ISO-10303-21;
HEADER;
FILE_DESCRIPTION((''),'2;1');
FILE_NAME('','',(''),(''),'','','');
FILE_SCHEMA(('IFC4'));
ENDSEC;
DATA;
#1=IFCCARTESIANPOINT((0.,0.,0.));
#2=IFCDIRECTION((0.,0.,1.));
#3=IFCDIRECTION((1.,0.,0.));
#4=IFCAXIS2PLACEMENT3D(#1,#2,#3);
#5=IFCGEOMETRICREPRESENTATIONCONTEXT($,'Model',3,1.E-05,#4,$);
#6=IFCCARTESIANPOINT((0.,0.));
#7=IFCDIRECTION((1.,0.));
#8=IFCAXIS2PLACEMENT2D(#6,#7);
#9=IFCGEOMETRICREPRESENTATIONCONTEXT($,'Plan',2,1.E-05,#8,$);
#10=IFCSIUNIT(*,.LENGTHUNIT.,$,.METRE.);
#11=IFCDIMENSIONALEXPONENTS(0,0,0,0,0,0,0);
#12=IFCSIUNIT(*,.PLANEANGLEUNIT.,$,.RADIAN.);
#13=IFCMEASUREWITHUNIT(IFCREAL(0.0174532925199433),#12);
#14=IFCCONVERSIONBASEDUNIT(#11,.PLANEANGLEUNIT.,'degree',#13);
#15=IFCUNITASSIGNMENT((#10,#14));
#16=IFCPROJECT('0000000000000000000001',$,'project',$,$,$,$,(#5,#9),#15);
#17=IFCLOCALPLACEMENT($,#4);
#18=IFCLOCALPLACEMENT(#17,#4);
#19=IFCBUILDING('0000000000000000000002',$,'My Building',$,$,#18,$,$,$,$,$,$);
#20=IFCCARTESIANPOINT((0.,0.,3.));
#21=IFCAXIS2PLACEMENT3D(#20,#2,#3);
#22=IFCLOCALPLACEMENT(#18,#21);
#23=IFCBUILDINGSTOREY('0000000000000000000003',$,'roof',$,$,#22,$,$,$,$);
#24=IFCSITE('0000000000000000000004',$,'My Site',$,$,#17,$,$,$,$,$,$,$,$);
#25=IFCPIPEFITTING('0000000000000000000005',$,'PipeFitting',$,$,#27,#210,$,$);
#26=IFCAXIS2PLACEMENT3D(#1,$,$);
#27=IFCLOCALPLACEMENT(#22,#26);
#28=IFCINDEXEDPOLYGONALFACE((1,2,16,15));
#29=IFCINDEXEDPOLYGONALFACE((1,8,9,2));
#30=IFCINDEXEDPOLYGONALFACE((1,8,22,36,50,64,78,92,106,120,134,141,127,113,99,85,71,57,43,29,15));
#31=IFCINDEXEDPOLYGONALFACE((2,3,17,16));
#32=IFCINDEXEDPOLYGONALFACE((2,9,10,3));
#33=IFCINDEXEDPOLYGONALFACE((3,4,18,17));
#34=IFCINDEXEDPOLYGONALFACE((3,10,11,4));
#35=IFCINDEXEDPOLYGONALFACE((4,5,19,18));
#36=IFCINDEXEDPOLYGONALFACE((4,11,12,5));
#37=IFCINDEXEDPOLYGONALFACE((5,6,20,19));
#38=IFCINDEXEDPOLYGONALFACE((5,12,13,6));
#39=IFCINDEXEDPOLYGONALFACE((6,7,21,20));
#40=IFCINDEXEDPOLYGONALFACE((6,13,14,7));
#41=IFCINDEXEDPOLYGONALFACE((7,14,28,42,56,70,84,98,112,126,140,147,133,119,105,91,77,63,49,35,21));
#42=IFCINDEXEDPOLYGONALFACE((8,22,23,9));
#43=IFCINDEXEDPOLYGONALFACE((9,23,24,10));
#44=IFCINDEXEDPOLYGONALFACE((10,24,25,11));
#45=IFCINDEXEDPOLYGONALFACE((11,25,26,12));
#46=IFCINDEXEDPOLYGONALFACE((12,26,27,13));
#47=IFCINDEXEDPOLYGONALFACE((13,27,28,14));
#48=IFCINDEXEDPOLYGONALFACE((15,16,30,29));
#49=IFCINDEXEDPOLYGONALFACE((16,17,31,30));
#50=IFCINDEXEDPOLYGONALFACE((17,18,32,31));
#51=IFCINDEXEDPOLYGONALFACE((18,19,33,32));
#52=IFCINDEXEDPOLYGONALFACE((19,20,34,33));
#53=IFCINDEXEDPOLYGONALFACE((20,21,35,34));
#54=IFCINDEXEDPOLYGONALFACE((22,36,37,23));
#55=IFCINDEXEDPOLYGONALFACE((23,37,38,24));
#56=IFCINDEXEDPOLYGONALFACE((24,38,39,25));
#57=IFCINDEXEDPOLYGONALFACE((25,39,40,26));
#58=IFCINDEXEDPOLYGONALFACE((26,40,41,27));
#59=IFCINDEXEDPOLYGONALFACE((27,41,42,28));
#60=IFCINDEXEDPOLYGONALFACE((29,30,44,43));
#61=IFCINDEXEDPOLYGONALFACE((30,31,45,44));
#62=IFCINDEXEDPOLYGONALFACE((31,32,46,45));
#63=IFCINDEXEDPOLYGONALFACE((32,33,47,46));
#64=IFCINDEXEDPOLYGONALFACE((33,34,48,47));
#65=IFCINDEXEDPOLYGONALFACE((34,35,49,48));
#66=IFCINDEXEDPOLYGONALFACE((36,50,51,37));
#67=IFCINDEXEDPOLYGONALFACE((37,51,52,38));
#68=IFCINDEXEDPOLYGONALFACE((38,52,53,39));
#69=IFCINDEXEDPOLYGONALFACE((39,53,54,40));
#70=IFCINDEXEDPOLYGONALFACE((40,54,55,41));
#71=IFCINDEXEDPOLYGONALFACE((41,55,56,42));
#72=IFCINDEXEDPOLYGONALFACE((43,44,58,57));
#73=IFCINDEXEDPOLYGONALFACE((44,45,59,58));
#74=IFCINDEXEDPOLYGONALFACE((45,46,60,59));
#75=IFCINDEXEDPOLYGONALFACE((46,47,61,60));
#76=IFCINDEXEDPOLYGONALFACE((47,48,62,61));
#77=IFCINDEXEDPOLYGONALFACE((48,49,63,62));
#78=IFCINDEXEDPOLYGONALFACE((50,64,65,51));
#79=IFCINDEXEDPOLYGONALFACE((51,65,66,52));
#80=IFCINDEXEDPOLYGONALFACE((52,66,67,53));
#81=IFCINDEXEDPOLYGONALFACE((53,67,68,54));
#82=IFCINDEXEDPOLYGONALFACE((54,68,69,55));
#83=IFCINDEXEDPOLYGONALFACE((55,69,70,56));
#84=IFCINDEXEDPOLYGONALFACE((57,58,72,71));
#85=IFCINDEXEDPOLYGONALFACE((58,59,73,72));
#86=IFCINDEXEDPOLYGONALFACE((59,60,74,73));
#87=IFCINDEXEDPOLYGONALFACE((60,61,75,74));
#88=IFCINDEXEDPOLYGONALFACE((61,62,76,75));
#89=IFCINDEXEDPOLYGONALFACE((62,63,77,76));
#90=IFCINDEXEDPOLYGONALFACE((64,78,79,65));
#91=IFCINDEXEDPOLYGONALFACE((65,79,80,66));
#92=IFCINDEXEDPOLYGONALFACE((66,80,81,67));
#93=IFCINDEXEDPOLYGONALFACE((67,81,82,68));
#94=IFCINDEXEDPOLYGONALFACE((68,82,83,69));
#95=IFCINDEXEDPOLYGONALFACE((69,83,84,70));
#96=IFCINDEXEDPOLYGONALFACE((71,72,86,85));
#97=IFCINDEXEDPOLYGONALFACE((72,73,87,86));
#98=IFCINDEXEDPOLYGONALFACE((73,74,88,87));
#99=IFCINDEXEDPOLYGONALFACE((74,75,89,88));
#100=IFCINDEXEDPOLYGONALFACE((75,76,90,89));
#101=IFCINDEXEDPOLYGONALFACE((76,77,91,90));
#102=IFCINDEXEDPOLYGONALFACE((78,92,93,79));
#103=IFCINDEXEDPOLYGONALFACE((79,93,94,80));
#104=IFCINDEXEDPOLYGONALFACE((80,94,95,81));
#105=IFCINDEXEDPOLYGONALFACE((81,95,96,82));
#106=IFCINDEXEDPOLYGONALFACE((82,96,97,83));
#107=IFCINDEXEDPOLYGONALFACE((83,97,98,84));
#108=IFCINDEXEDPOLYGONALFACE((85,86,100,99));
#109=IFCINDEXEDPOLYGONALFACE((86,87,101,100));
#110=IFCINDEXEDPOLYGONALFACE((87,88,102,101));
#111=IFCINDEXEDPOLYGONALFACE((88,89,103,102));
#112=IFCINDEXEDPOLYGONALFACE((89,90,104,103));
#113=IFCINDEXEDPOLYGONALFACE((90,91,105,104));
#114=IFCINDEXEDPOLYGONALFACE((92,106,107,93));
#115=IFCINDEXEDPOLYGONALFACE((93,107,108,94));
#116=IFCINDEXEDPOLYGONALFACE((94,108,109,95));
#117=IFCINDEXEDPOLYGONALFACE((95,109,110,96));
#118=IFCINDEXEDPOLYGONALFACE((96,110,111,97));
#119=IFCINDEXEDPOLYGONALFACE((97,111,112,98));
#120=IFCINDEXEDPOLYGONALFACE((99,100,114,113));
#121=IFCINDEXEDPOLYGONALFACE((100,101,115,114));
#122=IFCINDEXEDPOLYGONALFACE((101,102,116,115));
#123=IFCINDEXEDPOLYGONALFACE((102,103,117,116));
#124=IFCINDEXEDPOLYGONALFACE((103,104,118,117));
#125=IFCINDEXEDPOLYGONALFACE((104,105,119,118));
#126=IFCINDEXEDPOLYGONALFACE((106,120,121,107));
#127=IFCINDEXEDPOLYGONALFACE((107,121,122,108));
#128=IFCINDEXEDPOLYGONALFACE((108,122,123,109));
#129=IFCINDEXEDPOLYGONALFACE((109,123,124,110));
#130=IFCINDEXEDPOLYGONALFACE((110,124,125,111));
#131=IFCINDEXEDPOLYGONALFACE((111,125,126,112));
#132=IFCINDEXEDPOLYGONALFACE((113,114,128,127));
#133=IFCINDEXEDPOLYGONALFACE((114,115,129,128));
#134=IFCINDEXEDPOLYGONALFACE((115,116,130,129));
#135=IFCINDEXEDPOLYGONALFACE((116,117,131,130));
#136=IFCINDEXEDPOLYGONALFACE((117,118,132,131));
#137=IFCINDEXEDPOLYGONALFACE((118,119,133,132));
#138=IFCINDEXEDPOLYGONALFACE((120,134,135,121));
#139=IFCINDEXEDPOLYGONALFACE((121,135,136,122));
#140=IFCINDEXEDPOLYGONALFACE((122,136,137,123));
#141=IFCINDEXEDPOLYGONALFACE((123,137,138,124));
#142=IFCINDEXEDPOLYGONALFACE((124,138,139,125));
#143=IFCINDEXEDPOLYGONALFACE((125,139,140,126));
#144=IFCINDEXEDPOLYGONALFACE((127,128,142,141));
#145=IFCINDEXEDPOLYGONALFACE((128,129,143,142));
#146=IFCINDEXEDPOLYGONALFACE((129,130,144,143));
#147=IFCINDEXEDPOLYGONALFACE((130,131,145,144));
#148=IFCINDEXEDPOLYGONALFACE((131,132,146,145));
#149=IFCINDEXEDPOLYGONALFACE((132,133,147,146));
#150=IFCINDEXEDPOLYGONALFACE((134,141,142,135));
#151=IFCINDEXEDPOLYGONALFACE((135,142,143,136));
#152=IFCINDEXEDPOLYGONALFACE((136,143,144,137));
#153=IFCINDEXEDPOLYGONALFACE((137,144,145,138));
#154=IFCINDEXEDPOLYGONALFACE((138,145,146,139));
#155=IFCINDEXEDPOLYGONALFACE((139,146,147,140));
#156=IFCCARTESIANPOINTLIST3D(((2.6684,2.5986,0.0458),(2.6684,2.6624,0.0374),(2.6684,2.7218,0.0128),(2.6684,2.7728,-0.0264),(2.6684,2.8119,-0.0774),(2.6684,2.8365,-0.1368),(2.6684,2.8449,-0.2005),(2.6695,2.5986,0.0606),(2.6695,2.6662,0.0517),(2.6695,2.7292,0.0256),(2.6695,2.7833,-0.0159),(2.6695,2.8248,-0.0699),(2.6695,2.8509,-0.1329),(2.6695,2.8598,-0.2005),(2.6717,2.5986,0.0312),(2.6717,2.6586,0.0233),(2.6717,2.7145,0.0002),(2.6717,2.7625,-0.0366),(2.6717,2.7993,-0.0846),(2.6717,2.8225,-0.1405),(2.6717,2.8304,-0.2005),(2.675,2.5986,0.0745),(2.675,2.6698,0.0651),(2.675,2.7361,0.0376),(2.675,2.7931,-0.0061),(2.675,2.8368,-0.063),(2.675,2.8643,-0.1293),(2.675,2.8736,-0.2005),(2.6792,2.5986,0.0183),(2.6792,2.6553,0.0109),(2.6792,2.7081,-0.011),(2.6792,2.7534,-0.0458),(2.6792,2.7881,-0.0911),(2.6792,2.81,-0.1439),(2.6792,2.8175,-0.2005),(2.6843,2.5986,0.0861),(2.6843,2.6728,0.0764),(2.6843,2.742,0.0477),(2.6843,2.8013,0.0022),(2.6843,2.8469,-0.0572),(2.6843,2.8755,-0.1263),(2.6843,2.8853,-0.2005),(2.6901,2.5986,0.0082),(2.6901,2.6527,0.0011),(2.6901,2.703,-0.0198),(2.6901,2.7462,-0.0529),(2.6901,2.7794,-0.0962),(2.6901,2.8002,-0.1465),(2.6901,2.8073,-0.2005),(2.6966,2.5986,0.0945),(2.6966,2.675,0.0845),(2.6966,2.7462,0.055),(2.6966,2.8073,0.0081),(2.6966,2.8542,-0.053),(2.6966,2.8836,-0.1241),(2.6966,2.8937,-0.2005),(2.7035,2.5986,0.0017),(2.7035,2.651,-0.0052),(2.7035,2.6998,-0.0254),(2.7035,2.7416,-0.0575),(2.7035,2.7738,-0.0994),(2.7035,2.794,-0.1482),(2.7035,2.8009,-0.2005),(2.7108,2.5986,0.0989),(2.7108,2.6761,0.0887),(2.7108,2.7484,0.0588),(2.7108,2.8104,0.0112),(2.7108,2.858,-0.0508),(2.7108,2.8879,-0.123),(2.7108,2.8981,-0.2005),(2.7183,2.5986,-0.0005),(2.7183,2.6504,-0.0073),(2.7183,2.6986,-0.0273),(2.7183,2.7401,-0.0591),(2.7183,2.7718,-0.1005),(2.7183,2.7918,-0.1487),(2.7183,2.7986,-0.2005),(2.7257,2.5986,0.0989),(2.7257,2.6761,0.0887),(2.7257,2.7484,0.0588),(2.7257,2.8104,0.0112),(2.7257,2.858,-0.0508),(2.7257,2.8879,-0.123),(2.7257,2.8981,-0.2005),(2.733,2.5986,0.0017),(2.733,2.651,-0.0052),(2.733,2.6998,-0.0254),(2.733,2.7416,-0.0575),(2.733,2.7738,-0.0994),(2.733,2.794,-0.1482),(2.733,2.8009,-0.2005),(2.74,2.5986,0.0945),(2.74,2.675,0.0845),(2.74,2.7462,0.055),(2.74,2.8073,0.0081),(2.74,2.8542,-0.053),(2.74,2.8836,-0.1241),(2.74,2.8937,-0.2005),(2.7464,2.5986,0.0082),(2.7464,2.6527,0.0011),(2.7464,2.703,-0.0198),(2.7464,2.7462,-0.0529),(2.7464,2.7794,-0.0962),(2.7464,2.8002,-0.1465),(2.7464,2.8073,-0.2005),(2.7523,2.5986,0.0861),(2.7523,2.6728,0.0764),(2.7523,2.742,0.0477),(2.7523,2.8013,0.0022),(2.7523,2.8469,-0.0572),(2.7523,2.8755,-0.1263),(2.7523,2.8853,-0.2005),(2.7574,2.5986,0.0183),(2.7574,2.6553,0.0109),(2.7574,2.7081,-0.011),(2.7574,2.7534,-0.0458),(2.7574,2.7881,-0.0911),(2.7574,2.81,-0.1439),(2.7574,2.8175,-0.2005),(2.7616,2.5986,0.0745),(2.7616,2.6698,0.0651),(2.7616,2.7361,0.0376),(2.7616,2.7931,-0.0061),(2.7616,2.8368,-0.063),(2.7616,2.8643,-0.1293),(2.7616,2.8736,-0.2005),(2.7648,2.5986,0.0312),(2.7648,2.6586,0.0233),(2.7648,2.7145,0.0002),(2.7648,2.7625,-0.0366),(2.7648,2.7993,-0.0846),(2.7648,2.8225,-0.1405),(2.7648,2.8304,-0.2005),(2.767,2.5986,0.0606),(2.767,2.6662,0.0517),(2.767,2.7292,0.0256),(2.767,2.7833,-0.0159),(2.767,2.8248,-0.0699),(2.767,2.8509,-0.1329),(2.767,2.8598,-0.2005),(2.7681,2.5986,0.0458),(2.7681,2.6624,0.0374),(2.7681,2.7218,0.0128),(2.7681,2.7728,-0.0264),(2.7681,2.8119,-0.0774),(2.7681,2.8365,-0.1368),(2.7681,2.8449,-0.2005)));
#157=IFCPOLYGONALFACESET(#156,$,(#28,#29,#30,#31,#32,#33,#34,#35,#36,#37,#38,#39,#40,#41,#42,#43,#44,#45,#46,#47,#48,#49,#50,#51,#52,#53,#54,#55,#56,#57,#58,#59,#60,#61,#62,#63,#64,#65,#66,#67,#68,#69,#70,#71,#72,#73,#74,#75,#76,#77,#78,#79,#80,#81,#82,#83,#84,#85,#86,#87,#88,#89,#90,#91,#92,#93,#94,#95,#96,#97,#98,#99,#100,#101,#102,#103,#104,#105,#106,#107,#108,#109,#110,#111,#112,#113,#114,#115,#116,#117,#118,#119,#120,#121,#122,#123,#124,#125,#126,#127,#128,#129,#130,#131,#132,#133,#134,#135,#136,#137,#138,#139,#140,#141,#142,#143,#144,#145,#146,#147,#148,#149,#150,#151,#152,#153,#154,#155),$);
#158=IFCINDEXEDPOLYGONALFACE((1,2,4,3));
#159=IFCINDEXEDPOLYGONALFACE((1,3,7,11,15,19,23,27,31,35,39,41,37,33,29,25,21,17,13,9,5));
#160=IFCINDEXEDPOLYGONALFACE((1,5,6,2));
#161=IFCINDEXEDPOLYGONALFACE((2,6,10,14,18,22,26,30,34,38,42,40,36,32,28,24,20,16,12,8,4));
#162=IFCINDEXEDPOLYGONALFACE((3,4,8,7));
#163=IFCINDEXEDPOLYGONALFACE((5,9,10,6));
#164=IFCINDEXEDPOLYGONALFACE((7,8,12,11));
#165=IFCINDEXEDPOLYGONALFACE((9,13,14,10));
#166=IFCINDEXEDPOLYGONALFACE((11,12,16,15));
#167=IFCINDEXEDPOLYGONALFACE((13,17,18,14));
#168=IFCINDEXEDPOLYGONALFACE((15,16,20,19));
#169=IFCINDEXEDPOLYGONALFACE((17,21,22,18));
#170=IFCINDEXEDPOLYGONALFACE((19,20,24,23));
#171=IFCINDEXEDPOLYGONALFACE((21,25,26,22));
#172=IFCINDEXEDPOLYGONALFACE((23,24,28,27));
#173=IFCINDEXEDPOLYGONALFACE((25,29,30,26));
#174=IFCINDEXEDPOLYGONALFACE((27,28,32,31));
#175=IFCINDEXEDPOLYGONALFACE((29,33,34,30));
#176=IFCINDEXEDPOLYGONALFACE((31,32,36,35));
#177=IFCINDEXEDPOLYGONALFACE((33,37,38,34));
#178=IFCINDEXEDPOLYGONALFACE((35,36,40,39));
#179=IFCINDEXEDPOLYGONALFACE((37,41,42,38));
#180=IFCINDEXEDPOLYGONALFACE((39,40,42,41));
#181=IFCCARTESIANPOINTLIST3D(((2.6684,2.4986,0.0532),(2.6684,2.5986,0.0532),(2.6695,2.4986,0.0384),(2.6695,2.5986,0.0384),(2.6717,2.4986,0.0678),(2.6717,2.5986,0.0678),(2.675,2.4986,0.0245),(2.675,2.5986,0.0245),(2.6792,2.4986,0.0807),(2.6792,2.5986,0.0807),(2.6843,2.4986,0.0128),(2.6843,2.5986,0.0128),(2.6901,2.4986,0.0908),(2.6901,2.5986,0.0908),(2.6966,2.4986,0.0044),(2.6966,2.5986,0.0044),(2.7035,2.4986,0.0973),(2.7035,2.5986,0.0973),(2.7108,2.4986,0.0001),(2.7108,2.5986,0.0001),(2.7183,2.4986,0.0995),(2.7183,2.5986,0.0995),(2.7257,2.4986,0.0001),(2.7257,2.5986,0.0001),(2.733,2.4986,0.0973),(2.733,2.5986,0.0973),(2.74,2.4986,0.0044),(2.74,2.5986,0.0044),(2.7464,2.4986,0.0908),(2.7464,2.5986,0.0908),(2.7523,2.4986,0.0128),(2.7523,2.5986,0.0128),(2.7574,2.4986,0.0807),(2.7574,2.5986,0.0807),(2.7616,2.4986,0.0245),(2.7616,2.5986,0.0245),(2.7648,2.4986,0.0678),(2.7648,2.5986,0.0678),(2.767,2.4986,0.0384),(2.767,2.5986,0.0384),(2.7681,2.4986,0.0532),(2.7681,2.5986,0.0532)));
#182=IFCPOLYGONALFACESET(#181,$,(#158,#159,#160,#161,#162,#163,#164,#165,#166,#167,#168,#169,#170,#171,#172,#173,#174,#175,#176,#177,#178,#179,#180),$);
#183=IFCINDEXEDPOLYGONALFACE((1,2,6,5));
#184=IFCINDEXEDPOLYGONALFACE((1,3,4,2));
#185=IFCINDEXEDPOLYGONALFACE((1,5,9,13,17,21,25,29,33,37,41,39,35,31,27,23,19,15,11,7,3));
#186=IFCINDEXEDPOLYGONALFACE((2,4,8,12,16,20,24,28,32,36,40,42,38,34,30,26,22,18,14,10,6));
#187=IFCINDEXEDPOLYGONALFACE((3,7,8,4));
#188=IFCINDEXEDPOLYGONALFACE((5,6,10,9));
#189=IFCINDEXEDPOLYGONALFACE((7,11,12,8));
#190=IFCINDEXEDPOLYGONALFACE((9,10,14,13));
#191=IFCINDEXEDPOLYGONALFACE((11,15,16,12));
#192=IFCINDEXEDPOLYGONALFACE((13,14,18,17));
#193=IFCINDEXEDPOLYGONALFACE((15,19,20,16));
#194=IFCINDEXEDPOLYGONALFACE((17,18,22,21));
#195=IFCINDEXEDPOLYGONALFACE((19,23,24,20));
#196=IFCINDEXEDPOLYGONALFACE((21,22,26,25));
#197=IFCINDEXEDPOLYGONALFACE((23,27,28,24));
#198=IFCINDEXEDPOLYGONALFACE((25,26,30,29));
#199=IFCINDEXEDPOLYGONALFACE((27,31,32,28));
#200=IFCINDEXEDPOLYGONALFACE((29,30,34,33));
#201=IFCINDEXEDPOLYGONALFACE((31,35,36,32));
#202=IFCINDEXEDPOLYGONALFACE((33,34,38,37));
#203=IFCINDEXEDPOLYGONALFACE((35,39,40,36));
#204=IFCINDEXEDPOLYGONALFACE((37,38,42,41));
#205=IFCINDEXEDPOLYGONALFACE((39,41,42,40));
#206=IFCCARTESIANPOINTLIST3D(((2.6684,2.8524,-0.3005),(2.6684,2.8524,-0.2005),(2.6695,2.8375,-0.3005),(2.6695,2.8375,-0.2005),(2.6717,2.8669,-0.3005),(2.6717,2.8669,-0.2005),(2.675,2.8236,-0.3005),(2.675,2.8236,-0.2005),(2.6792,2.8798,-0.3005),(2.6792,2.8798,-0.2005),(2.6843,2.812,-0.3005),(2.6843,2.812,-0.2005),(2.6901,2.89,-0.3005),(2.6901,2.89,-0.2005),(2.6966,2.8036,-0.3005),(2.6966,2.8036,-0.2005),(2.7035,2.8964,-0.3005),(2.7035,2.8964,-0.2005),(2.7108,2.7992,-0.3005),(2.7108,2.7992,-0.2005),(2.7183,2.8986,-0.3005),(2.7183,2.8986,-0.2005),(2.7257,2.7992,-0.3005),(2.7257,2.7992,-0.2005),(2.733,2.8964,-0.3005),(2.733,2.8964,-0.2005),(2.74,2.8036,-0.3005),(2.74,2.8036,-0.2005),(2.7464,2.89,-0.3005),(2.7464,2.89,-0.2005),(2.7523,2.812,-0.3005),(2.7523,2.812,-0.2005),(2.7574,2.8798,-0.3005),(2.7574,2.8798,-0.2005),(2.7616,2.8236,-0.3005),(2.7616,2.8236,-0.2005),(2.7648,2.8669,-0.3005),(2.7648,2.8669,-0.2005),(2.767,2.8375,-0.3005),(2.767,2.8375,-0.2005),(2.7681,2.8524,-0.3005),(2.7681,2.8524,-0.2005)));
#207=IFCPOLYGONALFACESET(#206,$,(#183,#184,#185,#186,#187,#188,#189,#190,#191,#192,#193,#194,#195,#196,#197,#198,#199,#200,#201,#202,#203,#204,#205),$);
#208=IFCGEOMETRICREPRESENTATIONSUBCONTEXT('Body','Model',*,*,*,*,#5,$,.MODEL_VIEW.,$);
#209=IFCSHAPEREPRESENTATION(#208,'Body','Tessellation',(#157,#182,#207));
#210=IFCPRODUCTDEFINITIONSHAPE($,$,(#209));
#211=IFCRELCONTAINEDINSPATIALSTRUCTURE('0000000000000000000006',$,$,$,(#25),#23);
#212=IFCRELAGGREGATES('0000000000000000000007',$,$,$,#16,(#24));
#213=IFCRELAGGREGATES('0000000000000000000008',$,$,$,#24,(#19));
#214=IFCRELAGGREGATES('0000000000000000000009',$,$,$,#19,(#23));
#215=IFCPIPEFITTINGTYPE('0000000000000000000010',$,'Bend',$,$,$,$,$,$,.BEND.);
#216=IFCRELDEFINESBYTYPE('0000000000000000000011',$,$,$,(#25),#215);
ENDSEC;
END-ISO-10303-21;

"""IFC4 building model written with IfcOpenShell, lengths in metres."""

from ifc_helpers import new_model, entity, si_unit, converted_unit, frame, origin_with_axes, origin_2d_with_axis, place, context, subcontext, project, spatial, circle, extrude, source, transform, mapped, type_object, type_shapes, element, save


model = new_model("IFC4")

# Units and contexts
model_context = context("Model", 3, precision=1e-05, world=origin_with_axes())
plan_context = context("Plan", 2, precision=1e-05, world=origin_2d_with_axis())
body_context = subcontext(model_context, "Body", "Model", "MODEL_VIEW")
ifc_project = project(units=[si_unit("LENGTHUNIT", "METRE"), converted_unit("PLANEANGLEUNIT", "degree", entity("IfcReal", 0.0174532925199433), si_unit("PLANEANGLEUNIT", "RADIAN"), dimensions=[0, 0, 0, 0, 0, 0, 0])], contexts=[model_context, plan_context])

# Site, building, storey
site_placement = place(None, origin_with_axes())
site = spatial("IfcSite", under=ifc_project, at=site_placement, Name="My Site")
building_placement = place(site_placement, origin_with_axes())
building = spatial("IfcBuilding", under=site, at=building_placement, Name="My Building")
storey_placement = place(building_placement, frame((0.0, 0.0, 3.0), z_axis=(0.0, 0.0, 1.0), x_axis=(1.0, 0.0, 0.0)))
storey = spatial("IfcBuildingStorey", under=building, at=storey_placement, Name="roof")

# Pipe fitting
pipe_fitting_type_1 = type_object("IfcPipeFittingType", Name="Bend", PredefinedType="BEND")
shared_shape_1 = source(origin_with_axes(), body_context, "Body", "SolidModel", [
    entity("IfcSweptDiskSolid", entity("IfcIndexedPolyCurve", entity("IfcCartesianPointList3D", [[0.0, 0.0, -0.1], [-0.0732, 0.0, -0.2768], [-0.25, 0.0, -0.35]]), [entity("IfcArcIndex", [1, 2, 3])]), 0.05),
    extrude(circle(Radius=0.05), origin_with_axes(), (0.0, 0.0, -1.0), 0.1),
    extrude(circle(Radius=0.05), frame((-0.25, 0.0, -0.35), z_axis=(-1.0, 0.0, 0.0), x_axis=(0.0, 0.0, -1.0)), (0.0, 0.0, 1.0), 0.1),
])
type_shapes(pipe_fitting_type_1, [shared_shape_1])
for number, where, z_axis, x_axis, name in (
    (1, (2.7183, 2.4986, 0.0495), (0.0, -1.0, 0.0), (0.000003, 0.0, 1.0), "PipeFitting"),
):
    element("IfcPipeFitting", number, at=place(storey_placement, frame(where, z_axis=z_axis, x_axis=x_axis)), inside=storey, type_object=pipe_fitting_type_1, Name=name, context=body_context, shape_type="MappedRepresentation", body=[
        mapped(shared_shape_1, transform((0.0, 0.0, 0.0), x_axis=(1.0, 0.0, 0.0), y_axis=(0.0, 1.0, 0.0), z_axis=(0.0, 0.0, 1.0), scale=1.0)),
    ])

save(model, "model.ifc")
